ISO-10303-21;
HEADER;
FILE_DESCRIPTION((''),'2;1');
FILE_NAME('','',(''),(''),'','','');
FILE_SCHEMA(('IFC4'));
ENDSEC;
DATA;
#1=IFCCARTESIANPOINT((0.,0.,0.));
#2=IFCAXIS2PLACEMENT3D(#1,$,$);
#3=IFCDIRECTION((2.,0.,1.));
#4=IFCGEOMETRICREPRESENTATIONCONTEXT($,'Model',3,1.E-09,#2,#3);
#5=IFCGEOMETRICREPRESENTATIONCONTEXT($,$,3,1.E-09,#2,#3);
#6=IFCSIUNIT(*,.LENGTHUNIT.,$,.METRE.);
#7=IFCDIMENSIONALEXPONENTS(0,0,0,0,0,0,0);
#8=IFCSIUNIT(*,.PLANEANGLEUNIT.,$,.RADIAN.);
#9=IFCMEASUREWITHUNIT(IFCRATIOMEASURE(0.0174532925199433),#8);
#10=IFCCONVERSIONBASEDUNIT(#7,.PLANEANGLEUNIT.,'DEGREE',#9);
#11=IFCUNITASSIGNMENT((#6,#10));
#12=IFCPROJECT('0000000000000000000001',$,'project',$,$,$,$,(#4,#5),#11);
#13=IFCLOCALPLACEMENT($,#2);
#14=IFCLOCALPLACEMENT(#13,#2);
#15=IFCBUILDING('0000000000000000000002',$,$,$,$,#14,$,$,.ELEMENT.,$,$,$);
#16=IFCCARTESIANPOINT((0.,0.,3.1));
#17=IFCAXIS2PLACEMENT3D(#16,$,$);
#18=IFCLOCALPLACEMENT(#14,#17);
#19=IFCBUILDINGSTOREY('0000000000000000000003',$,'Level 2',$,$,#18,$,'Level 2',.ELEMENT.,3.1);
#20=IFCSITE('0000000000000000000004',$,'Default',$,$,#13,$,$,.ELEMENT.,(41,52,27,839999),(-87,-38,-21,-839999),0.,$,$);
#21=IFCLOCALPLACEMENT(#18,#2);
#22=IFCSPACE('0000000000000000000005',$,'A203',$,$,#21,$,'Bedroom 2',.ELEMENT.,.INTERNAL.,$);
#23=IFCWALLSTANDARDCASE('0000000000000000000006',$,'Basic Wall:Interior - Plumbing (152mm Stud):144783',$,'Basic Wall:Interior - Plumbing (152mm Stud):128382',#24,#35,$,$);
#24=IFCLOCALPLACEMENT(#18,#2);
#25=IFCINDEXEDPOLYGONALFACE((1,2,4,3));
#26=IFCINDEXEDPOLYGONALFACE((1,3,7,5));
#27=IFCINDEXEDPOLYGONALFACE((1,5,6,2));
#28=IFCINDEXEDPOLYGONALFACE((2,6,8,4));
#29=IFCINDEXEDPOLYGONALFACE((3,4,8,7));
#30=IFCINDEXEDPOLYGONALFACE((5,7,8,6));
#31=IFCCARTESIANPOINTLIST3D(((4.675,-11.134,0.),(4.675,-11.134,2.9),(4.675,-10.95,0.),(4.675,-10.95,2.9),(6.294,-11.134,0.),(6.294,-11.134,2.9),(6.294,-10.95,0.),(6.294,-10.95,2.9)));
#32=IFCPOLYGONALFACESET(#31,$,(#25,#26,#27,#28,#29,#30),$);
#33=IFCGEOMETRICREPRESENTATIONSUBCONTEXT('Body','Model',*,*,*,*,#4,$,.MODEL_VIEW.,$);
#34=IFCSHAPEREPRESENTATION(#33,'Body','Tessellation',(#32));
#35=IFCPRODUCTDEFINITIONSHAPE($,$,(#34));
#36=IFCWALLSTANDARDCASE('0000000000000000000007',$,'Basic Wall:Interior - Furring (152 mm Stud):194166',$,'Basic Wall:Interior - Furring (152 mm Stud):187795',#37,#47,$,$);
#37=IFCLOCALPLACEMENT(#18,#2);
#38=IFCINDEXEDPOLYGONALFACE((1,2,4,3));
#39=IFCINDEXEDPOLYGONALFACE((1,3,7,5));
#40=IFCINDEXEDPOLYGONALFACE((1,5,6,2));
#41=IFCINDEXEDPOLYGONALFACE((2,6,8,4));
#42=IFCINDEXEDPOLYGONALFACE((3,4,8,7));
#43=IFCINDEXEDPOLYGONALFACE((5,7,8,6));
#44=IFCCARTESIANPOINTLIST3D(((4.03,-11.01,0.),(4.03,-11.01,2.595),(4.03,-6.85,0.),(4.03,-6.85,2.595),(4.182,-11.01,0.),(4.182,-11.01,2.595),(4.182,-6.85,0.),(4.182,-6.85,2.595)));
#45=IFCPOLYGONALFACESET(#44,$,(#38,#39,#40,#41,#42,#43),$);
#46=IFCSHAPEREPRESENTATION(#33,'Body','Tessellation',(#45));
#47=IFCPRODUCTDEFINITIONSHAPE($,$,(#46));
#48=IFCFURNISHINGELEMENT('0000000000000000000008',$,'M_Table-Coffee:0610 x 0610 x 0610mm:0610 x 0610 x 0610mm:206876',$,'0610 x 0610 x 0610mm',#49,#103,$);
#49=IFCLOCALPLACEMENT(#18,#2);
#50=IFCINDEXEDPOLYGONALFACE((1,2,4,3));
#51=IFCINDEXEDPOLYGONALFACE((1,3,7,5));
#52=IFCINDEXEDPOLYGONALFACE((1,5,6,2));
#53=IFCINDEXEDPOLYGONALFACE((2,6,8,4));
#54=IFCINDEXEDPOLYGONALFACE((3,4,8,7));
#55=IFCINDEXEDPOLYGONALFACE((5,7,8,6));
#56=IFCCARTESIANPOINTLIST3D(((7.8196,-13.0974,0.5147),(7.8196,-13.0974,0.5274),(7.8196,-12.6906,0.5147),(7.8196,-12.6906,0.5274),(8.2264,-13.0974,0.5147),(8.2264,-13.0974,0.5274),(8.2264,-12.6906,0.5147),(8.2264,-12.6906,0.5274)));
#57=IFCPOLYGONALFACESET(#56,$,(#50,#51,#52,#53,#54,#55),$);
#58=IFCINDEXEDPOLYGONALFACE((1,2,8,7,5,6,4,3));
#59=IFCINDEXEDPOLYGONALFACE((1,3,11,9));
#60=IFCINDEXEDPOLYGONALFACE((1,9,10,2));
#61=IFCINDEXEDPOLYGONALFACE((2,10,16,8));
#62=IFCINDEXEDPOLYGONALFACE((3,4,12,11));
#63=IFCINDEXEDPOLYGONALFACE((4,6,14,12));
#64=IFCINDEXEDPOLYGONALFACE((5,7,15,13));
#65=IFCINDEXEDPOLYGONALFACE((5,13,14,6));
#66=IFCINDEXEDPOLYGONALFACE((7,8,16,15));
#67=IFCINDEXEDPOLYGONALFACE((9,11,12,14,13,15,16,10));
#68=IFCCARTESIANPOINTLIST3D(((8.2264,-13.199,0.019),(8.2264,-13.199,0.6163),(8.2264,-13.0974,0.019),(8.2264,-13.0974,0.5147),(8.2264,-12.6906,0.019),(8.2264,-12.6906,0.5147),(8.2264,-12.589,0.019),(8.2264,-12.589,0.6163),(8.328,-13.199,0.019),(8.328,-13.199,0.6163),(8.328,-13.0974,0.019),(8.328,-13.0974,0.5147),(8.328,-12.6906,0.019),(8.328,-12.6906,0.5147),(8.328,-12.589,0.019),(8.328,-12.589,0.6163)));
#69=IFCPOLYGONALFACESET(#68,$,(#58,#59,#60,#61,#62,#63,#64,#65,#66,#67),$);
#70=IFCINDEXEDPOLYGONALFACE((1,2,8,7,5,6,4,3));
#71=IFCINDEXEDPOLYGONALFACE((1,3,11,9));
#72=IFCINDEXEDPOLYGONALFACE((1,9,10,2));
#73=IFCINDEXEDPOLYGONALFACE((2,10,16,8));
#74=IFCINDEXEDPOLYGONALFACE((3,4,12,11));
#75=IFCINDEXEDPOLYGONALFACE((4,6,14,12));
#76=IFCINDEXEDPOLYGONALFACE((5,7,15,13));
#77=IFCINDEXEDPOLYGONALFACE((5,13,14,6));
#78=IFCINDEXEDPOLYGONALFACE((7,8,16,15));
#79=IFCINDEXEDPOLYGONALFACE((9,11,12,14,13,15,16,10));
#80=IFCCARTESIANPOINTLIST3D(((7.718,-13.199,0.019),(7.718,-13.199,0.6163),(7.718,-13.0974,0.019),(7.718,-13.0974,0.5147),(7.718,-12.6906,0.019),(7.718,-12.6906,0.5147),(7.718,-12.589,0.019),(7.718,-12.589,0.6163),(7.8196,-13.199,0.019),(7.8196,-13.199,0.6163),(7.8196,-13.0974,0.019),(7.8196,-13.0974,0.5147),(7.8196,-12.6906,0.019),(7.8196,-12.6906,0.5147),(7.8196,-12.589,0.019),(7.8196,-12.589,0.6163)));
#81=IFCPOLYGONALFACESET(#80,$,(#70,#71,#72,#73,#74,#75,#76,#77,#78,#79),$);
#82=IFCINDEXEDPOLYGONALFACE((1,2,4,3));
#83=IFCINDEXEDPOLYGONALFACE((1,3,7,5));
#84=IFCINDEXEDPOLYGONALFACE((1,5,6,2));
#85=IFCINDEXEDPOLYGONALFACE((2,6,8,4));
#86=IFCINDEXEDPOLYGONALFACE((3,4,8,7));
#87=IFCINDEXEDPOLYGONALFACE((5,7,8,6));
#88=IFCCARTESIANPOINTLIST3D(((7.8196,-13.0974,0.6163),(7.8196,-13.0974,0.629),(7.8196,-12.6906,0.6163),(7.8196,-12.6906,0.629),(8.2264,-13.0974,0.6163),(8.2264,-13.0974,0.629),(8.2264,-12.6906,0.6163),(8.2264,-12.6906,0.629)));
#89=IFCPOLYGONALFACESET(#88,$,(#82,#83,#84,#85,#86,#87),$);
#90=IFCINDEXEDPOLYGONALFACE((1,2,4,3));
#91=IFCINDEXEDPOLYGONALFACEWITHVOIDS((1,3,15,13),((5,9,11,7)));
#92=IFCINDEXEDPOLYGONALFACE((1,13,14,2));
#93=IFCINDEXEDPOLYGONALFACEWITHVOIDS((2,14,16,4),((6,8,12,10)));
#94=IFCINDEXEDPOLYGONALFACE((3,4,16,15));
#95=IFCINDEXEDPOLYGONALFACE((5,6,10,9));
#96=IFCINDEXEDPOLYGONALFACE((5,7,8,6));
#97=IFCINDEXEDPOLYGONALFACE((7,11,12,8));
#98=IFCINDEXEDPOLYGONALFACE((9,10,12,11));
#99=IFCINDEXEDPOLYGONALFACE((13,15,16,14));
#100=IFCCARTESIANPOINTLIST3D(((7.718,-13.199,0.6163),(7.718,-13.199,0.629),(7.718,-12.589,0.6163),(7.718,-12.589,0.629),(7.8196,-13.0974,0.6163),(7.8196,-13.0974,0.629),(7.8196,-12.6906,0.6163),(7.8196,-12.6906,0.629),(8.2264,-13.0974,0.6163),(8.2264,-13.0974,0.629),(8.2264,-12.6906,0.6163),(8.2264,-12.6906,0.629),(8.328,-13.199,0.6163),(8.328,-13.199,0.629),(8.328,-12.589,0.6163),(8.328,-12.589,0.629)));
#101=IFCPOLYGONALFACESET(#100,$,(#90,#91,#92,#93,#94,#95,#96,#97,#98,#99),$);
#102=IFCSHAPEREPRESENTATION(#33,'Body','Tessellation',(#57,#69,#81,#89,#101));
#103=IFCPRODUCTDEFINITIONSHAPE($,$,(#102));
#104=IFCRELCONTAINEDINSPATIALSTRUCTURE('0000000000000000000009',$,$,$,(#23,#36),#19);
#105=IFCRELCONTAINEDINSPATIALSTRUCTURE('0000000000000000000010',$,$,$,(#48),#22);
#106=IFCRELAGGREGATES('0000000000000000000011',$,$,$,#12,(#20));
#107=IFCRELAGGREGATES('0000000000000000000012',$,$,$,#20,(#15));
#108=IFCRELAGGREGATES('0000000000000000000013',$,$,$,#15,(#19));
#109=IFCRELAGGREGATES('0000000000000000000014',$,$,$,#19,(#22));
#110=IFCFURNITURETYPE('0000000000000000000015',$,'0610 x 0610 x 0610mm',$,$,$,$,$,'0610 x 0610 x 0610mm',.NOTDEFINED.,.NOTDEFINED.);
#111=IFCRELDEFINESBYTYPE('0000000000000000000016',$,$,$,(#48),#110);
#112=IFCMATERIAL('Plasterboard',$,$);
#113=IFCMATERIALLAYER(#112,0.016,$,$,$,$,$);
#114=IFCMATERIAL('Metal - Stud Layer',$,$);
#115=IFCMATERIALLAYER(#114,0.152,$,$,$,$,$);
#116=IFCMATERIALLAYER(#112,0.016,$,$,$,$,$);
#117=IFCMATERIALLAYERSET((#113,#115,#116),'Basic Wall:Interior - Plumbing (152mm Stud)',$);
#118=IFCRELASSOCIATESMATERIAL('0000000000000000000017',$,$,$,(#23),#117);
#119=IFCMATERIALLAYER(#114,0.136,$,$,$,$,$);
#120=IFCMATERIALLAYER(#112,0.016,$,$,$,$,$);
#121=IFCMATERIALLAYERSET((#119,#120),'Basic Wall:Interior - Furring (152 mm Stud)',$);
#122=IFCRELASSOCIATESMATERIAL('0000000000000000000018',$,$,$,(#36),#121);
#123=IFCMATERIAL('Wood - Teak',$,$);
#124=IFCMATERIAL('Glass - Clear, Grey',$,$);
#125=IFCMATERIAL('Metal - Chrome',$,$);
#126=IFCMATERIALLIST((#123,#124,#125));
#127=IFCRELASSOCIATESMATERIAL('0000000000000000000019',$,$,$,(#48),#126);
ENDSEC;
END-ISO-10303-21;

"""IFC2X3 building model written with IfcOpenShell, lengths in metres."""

from ifc_helpers import new_model, entity, si_unit, converted_unit, direction, frame, frame_2d, origin, origin_2d_with_axis, place, context, subcontext, project, spatial, polyline, rectangle, outline, extrude, source, transform, mapped, material, material_list, layer, layer_set, layer_usage, type_object, type_shapes, element, save


model = new_model("IFC2X3")

# Units and contexts
model_context = context("Model", 3, precision=1e-09, world=origin(), true_north=direction((2.0, 0.0, 1.0)))
context_of_model = context(None, 3, precision=1e-09, world=origin(), true_north=direction((2.0, 0.0, 1.0)))
body_context = subcontext(model_context, "Body", "Model", "MODEL_VIEW")
ifc_project = project(units=[si_unit("LENGTHUNIT", "METRE"), converted_unit("PLANEANGLEUNIT", "DEGREE", entity("IfcRatioMeasure", 0.0174532925199433), si_unit("PLANEANGLEUNIT", "RADIAN"), dimensions=[0, 0, 0, 0, 0, 0, 0])], contexts=[model_context, context_of_model])

# Site, building, storey
site_placement = place(None, origin())
site = spatial("IfcSite", under=ifc_project, at=site_placement, Name="Default", CompositionType="ELEMENT", RefLatitude=(41, 52, 27, 839999), RefLongitude=(-87, -38, -21, -839999), RefElevation=0.0)
building_placement = place(site_placement, origin())
building = spatial("IfcBuilding", under=site, at=building_placement, CompositionType="ELEMENT")
storey_placement = place(building_placement, frame((0.0, 0.0, 3.1)))
storey = spatial("IfcBuildingStorey", under=building, at=storey_placement, Name="Level 2", LongName="Level 2", CompositionType="ELEMENT", Elevation=3.1)

# Shared definitions
ifc_material_1 = material(Name="Metal - Stud Layer")
ifc_material_2 = material(Name="Plasterboard")

# Walls
ifc_layer_1 = layer(ifc_material_2, 0.016)
ifc_layer_2 = layer(ifc_material_1, 0.152)
ifc_layer_3 = layer(ifc_material_2, 0.016)
ifc_layer_set_1 = layer_set([ifc_layer_1, ifc_layer_2, ifc_layer_3], Name="Basic Wall:Interior - Plumbing (152mm Stud)")
ifc_layer_usage_1 = layer_usage(ifc_layer_set_1, "AXIS2", "NEGATIVE", 0.092)
wall_1_placement = place(storey_placement, frame((6.294, -11.042, 0.0), z_axis=(0.0, 0.0, 1.0), x_axis=(-1.0, 0.0, 0.0)))
element("IfcWallStandardCase", 1, at=wall_1_placement, inside=storey, material=ifc_layer_usage_1, Name="Basic Wall:Interior - Plumbing (152mm Stud):144783", ObjectType="Basic Wall:Interior - Plumbing (152mm Stud):128382", context=body_context, shape_type="SweptSolid", body=[
    extrude(rectangle(XDim=1.619, YDim=0.184, at=frame_2d((0.8095, 0.0), x_axis=(-1.0, 0.0))), origin(), (0.0, 0.0, 1.0), 2.9),
])
ifc_layer_4 = layer(ifc_material_1, 0.136)
ifc_layer_5 = layer(ifc_material_2, 0.016)
ifc_layer_set_2 = layer_set([ifc_layer_4, ifc_layer_5], Name="Basic Wall:Interior - Furring (152 mm Stud)")
ifc_layer_usage_2 = layer_usage(ifc_layer_set_2, "AXIS2", "POSITIVE", -0.076)
wall_2_placement = place(storey_placement, frame((4.106, -11.01, 0.0), z_axis=(0.0, 0.0, 1.0), x_axis=(0.0, 1.0, 0.0)))
element("IfcWallStandardCase", 2, at=wall_2_placement, inside=storey, material=ifc_layer_usage_2, Name="Basic Wall:Interior - Furring (152 mm Stud):194166", ObjectType="Basic Wall:Interior - Furring (152 mm Stud):187795", context=body_context, shape_type="SweptSolid", body=[
    extrude(rectangle(XDim=4.16, YDim=0.152, at=frame_2d((2.08, 0.0), x_axis=(-1.0, 0.0))), origin(), (0.0, 0.0, 1.0), 2.595),
])

# Shared definitions
space_placement = place(storey_placement, origin())
space = spatial("IfcSpace", under=storey, at=space_placement, Name="A203", LongName="Bedroom 2", CompositionType="ELEMENT", InteriorOrExteriorSpace="INTERNAL")

# Furnishing element
ifc_material_3 = material(Name="Wood - Teak")
ifc_material_4 = material(Name="Glass - Clear, Grey")
ifc_material_5 = material(Name="Metal - Chrome")
ifc_material_list_1 = material_list([ifc_material_3, ifc_material_4, ifc_material_5])
furniture_type_1 = type_object("IfcFurnitureType", Name="0610 x 0610 x 0610mm", ElementType="0610 x 0610 x 0610mm", AssemblyPlace="NOTDEFINED")
shared_shape_1 = source(origin(), body_context, "Body", "SweptSolid", [
    extrude(rectangle(XDim=0.4068, YDim=0.4068, at=origin_2d_with_axis()), frame((0.0183, 0.0952, 0.4957), z_axis=(0.0, 0.0, 1.0), x_axis=(-1.0, 0.0, 0.0)), (0.0, 0.0, 1.0), 0.0127),
    extrude(outline(polyline([(-0.2732, -0.305), (0.324, -0.305), (0.324, 0.305), (-0.2732, 0.305), (-0.2732, 0.2034), (0.2225, 0.2034), (0.2225, -0.2034), (-0.2732, -0.2034), (-0.2732, -0.305)])), frame((0.2217, 0.0952, 0.2732), z_axis=(1.0, 0.0, 0.0), x_axis=(0.0, 0.0, 1.0)), (0.0, 0.0, 1.0), 0.1016),
    extrude(outline(polyline([(-0.305, -0.3241), (0.305, -0.3241), (0.305, 0.2733), (0.2034, 0.2733), (0.2034, -0.2224), (-0.2034, -0.2224), (-0.2034, 0.2733), (-0.305, 0.2733), (-0.305, -0.3241)])), frame((-0.2867, 0.0952, 0.2733), z_axis=(1.0, 0.0, 0.0), x_axis=(0.0, -1.0, 0.0)), (0.0, 0.0, 1.0), 0.1016),
    extrude(rectangle(XDim=0.4068, YDim=0.4068, at=origin_2d_with_axis()), frame((0.0183, 0.0952, 0.5973), z_axis=(0.0, 0.0, 1.0), x_axis=(-1.0, 0.0, 0.0)), (0.0, 0.0, 1.0), 0.0127),
    extrude(outline(polyline([(-0.305, -0.305), (0.305, -0.305), (0.305, 0.305), (-0.305, 0.305), (-0.305, -0.305)]), holes=[polyline([(-0.2034, -0.2034), (-0.2034, 0.2034), (0.2034, 0.2034), (0.2034, -0.2034), (-0.2034, -0.2034)])]), frame((0.0183, 0.0952, 0.5973), z_axis=(0.0, 0.0, 1.0), x_axis=(-1.0, 0.0, 0.0)), (0.0, 0.0, 1.0), 0.0127),
])
type_shapes(furniture_type_1, [shared_shape_1])
furnishing_1_placement = place(space_placement, frame((8.0047, -12.9892, 0.019)))
element("IfcFurnishingElement", 3, at=furnishing_1_placement, inside=space, type_object=furniture_type_1, material=ifc_material_list_1, Name="M_Table-Coffee:0610 x 0610 x 0610mm:0610 x 0610 x 0610mm:206876", ObjectType="0610 x 0610 x 0610mm", context=body_context, shape_type="MappedRepresentation", body=[
    mapped(shared_shape_1, transform((0.0, 0.0, 0.0), scale=1.0)),
])

save(model, "model.ifc")
